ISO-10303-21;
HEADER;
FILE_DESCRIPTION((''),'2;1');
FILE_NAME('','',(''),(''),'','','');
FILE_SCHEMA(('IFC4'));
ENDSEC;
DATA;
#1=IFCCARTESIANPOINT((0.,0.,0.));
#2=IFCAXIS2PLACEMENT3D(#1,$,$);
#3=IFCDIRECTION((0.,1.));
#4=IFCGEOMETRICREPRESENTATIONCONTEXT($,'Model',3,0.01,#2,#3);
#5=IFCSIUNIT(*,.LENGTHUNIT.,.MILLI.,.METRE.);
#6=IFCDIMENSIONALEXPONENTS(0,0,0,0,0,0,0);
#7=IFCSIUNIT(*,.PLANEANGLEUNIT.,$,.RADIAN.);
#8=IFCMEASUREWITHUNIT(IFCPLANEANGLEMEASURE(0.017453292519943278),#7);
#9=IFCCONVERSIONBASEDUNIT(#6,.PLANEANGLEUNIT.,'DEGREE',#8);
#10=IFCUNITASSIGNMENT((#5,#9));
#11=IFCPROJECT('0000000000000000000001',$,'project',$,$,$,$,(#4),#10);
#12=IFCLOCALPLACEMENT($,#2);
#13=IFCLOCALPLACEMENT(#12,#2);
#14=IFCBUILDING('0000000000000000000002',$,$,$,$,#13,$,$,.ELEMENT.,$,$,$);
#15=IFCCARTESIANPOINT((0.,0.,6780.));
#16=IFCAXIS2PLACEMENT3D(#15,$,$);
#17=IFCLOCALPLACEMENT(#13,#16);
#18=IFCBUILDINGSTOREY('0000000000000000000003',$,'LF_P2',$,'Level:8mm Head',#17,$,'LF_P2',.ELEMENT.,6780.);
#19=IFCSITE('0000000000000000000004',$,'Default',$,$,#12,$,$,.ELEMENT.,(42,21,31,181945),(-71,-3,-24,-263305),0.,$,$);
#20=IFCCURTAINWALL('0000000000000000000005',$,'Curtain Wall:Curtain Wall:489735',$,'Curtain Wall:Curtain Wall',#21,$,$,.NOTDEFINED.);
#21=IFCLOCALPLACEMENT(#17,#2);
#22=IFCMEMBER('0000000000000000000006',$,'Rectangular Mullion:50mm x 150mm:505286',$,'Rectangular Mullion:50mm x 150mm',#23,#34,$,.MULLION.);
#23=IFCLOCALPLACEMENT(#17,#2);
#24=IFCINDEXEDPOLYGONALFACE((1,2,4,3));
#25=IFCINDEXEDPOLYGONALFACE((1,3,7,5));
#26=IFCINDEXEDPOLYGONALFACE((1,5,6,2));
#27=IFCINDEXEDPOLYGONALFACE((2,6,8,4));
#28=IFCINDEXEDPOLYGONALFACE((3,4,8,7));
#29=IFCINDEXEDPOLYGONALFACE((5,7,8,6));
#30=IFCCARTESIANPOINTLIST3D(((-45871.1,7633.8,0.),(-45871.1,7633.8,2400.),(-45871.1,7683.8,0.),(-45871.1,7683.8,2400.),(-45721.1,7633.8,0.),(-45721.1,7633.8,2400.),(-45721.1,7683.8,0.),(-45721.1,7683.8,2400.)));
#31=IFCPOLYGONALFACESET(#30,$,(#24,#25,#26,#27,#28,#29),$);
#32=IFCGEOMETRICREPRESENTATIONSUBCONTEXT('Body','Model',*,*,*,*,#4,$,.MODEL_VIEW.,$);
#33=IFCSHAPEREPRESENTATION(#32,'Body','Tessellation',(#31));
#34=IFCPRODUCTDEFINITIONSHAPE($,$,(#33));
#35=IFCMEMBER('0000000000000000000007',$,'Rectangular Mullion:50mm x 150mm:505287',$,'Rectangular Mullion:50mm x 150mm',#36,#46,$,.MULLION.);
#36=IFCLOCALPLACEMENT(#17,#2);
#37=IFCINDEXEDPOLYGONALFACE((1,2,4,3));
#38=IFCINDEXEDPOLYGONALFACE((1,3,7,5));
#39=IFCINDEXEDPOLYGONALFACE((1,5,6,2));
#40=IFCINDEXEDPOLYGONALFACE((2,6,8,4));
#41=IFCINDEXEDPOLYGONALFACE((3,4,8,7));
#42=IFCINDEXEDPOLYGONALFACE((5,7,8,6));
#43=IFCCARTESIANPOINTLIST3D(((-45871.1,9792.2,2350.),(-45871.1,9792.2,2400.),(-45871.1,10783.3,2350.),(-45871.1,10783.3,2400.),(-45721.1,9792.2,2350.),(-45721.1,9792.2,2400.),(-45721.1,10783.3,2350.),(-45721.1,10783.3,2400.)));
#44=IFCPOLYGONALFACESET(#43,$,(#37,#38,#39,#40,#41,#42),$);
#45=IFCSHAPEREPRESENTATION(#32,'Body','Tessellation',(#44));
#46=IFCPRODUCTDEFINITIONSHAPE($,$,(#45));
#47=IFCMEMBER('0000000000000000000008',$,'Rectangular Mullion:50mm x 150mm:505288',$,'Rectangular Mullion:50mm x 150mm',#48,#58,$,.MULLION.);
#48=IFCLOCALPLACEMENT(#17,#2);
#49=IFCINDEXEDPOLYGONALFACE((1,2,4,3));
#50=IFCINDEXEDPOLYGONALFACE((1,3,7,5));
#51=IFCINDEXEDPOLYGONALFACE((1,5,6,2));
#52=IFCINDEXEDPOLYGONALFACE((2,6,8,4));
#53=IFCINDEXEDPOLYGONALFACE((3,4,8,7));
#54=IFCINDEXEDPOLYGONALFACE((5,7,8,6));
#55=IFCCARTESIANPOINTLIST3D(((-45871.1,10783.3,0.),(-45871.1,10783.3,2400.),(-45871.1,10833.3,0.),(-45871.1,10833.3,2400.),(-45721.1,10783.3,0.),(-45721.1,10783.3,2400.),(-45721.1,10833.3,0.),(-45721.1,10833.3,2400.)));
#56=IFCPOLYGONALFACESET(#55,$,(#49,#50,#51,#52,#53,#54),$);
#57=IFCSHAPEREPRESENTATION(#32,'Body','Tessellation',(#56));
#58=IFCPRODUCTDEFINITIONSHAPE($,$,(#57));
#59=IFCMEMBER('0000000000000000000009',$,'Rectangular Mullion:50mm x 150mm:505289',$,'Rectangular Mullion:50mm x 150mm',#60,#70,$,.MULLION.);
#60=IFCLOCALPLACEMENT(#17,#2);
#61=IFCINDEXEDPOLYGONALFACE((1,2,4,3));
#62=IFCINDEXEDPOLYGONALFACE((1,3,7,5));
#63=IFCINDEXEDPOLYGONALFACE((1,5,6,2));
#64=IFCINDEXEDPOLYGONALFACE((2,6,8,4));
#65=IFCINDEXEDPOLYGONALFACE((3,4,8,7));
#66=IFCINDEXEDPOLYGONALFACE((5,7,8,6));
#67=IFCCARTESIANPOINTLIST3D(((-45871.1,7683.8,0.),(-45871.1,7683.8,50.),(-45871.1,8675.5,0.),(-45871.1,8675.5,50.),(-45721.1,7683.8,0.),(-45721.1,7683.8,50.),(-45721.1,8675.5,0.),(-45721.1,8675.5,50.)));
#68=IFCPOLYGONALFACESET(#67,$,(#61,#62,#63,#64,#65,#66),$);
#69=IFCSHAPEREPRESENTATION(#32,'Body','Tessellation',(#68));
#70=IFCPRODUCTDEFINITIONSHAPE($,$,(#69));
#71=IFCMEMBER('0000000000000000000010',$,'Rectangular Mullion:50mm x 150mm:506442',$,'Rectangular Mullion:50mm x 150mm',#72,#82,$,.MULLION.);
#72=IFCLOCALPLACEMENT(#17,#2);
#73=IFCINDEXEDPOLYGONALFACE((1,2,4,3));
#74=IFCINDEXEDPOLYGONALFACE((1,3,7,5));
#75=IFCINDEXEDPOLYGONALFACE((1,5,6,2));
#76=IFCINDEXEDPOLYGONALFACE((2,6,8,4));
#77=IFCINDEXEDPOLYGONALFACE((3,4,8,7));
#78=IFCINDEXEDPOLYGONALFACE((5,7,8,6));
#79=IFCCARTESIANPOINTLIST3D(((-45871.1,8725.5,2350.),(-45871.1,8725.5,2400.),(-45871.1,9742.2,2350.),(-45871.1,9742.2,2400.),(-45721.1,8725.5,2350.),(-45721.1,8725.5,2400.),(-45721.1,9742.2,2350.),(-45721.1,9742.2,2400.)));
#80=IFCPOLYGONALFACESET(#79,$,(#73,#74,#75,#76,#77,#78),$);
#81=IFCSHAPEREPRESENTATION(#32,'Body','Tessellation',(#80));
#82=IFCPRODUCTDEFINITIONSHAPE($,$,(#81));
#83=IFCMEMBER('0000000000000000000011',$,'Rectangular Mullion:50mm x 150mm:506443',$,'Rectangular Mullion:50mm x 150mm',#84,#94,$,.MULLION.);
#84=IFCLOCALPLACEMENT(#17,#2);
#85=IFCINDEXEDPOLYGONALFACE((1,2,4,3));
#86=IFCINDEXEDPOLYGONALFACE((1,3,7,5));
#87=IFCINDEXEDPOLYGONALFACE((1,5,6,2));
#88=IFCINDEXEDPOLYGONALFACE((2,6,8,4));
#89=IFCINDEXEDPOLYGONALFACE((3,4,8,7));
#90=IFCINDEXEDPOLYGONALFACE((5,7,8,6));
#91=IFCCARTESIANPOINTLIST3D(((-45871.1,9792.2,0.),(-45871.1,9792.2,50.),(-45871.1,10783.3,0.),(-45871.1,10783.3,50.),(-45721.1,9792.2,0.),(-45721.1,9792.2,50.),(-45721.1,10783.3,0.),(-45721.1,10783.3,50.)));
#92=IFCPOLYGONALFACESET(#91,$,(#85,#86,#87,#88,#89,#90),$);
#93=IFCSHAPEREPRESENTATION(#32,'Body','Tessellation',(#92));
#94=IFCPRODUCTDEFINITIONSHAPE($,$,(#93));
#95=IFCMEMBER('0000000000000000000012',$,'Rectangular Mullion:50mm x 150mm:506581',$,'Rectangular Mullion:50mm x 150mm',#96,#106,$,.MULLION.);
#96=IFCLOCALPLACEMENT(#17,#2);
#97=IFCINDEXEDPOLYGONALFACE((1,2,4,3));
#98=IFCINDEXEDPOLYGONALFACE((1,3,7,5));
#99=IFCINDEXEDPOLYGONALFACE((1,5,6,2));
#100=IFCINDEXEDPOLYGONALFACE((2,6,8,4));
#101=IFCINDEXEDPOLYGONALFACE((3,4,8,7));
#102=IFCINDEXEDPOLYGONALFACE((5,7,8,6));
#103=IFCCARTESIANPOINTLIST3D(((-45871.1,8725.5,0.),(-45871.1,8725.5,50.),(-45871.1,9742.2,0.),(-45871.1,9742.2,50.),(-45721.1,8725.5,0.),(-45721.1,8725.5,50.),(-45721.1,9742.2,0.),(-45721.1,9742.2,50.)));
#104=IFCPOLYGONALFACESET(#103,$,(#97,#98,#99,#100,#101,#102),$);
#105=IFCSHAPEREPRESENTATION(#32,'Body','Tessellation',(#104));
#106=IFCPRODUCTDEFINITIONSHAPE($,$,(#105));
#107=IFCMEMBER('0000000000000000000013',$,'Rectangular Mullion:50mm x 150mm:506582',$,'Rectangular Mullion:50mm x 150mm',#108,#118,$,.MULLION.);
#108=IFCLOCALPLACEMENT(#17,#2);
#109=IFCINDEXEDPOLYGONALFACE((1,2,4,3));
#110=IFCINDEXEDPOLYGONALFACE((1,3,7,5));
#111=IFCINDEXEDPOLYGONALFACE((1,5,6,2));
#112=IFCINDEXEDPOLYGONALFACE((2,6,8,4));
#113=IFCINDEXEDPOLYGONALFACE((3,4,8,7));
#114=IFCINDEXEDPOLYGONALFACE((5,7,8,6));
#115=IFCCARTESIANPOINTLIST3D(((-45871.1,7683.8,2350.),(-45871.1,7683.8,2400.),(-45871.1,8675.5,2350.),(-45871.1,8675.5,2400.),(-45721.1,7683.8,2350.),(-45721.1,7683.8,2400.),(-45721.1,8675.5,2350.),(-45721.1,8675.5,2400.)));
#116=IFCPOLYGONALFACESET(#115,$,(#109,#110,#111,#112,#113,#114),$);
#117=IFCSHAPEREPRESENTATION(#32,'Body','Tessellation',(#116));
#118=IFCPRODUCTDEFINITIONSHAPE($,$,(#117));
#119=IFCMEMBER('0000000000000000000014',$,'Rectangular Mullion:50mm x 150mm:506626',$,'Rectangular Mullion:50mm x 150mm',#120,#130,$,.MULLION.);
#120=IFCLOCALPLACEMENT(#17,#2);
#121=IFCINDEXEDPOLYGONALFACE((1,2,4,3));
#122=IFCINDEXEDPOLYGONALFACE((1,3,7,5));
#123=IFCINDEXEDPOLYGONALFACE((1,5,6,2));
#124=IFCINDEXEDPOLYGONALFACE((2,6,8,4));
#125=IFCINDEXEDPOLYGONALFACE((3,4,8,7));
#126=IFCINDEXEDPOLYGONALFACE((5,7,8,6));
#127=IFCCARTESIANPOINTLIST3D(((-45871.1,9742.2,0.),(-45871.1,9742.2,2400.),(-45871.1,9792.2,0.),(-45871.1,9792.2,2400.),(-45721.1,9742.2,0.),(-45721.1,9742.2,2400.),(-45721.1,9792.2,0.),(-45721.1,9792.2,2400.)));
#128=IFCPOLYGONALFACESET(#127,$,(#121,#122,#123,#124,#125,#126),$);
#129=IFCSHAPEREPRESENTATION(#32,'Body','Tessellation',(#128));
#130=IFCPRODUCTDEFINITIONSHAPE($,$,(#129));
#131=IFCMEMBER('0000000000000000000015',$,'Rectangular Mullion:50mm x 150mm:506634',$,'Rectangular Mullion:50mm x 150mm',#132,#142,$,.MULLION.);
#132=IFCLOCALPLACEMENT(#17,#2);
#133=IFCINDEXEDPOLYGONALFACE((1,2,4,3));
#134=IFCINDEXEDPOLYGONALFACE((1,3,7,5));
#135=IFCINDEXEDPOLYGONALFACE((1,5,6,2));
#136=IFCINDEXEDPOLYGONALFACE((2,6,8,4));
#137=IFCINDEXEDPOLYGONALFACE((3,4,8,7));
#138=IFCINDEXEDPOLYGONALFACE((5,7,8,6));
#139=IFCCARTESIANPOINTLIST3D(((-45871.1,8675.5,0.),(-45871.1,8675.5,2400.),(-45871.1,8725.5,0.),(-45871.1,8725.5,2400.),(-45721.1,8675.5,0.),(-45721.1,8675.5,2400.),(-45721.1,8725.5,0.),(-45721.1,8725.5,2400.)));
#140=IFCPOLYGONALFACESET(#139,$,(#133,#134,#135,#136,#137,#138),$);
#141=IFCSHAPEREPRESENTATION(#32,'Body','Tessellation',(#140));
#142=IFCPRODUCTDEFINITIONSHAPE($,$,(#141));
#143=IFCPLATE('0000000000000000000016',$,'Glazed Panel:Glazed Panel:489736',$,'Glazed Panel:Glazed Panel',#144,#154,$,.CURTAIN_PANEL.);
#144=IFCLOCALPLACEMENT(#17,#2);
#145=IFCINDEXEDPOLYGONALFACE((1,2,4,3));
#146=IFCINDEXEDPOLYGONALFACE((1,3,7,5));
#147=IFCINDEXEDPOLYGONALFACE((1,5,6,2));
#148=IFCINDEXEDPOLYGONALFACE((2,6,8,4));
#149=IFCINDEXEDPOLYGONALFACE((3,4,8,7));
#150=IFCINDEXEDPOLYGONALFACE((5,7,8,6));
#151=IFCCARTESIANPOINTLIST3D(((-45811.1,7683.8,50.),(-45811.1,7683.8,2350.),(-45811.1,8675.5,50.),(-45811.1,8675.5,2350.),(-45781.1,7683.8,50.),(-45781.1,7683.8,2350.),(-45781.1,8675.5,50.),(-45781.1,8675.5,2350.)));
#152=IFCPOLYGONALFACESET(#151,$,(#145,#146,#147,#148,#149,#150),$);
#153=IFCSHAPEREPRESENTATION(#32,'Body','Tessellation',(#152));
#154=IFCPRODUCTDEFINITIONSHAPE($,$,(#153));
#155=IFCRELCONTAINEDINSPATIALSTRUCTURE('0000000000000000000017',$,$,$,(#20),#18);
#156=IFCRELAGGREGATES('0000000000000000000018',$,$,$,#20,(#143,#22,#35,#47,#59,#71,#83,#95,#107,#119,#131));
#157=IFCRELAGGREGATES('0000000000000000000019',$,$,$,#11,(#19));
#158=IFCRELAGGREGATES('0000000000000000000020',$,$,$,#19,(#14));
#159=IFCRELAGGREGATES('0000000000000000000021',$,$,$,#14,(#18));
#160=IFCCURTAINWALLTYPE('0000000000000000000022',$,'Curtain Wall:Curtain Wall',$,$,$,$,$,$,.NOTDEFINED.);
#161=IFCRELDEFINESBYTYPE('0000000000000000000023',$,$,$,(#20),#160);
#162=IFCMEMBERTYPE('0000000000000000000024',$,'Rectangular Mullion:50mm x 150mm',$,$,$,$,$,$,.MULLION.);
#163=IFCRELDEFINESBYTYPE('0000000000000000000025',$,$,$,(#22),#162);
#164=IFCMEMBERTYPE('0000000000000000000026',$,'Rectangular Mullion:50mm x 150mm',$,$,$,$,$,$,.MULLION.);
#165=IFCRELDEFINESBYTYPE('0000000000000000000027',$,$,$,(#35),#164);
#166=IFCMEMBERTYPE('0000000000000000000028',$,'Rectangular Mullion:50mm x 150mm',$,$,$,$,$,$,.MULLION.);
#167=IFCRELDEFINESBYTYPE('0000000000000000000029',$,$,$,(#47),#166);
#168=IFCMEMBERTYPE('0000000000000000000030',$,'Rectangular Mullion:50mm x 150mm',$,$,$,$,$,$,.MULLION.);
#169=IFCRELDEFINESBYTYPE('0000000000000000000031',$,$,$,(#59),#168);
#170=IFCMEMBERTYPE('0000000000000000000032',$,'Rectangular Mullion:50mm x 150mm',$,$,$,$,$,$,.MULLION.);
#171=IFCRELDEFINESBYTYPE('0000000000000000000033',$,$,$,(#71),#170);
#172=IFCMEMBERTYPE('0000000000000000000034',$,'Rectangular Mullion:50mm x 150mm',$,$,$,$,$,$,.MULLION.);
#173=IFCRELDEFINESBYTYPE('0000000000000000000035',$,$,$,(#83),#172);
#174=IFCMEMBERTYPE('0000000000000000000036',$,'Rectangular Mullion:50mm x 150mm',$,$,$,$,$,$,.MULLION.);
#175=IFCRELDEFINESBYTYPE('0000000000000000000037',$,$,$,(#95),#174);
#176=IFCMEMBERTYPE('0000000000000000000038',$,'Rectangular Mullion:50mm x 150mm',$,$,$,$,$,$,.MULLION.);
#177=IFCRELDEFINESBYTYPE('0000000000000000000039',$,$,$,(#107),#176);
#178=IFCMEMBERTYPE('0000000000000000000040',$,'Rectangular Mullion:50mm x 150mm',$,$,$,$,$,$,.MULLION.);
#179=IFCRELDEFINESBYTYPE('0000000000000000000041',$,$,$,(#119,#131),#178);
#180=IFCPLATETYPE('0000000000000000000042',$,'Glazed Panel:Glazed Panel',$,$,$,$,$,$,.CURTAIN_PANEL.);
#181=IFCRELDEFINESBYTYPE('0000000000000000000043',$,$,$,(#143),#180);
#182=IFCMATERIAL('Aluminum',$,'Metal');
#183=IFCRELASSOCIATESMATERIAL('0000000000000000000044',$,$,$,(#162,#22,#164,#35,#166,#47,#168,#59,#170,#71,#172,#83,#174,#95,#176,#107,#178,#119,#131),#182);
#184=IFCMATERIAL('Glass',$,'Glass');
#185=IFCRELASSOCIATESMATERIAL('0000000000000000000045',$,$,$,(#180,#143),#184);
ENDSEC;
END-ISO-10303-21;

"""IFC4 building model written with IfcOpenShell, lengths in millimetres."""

from ifc_helpers import new_model, entity, si_unit, converted_unit, direction, frame, origin, place, context, subcontext, project, spatial, indexed_curve, outline, extrude, source, transform, mapped, material, type_object, type_shapes, element, aggregate, save


model = new_model("IFC4")

# Units and contexts
model_context = context("Model", 3, precision=0.01, world=origin(), true_north=direction((0.0, 1.0)))
body_context = subcontext(model_context, "Body", "Model", "MODEL_VIEW")
ifc_project = project(units=[si_unit("LENGTHUNIT", "METRE", prefix="MILLI"), converted_unit("PLANEANGLEUNIT", "DEGREE", entity("IfcPlaneAngleMeasure", 0.017453292519943278), si_unit("PLANEANGLEUNIT", "RADIAN"), dimensions=[0, 0, 0, 0, 0, 0, 0])], contexts=[model_context])

# Site, building, storey
site_placement = place(None, origin())
site = spatial("IfcSite", under=ifc_project, at=site_placement, Name="Default", CompositionType="ELEMENT", RefLatitude=(42, 21, 31, 181945), RefLongitude=(-71, -3, -24, -263305), RefElevation=0.0)
building_placement = place(site_placement, origin())
building = spatial("IfcBuilding", under=site, at=building_placement, CompositionType="ELEMENT")
storey_placement = place(building_placement, frame((0.0, 0.0, 6780.0)))
storey = spatial("IfcBuildingStorey", under=building, at=storey_placement, Name="LF_P2", ObjectType="Level:8mm Head", LongName="LF_P2", CompositionType="ELEMENT", Elevation=6780.0)

# Curtain wall, members, plate
curtain_wall_type = type_object("IfcCurtainWallType", Name="Curtain Wall:Curtain Wall", PredefinedType="NOTDEFINED")
curtain_wall_placement = place(storey_placement, frame((0.0, 0.0, -6780.0)))
curtain_wall = element("IfcCurtainWall", 1, at=curtain_wall_placement, inside=storey, type_object=curtain_wall_type, Name="Curtain Wall:Curtain Wall:489735", ObjectType="Curtain Wall:Curtain Wall", PredefinedType="NOTDEFINED")
ifc_material_1 = material(Name="Aluminum", Category="Metal")
member_type_1 = type_object("IfcMemberType", Name="Rectangular Mullion:50mm x 150mm", PredefinedType="MULLION", material=ifc_material_1)
shared_shape_1 = source(origin(), body_context, "Body", "SweptSolid", [
    extrude(outline(indexed_curve([(-25.0, -75.0), (25.0, -75.0), (25.0, 75.0), (-25.0, 75.0), (-25.0, -75.0)], self_intersect=False)), frame((-25.0, 0.0, -2400.0), z_axis=(0.0, 0.0, 1.0), x_axis=(-1.0, 0.0, 0.0)), (0.0, 0.0, 1.0), 2400.0),
])
type_shapes(member_type_1, [shared_shape_1])
member_1_placement = place(curtain_wall_placement, frame((-45796.1, 7633.8, 9180.0), z_axis=(0.0, 0.0, 1.0), x_axis=(0.0, -1.0, 0.0)))
member_1 = element("IfcMember", 2, at=member_1_placement, type_object=member_type_1, material=ifc_material_1, Name="Rectangular Mullion:50mm x 150mm:505286", ObjectType="Rectangular Mullion:50mm x 150mm", PredefinedType="MULLION", context=body_context, shape_type="MappedRepresentation", body=[
    mapped(shared_shape_1, transform((0.0, 0.0, 0.0), scale=1.0)),
])
member_type_2 = type_object("IfcMemberType", Name="Rectangular Mullion:50mm x 150mm", PredefinedType="MULLION", material=ifc_material_1)
shared_shape_2 = source(origin(), body_context, "Body", "SweptSolid", [
    extrude(outline(indexed_curve([(-25.0, -75.0), (25.0, -75.0), (25.0, 75.0), (-25.0, 75.0), (-25.0, -75.0)], self_intersect=False)), frame((-25.0, 0.0, -991.2), z_axis=(0.0, 0.0, 1.0), x_axis=(-1.0, 0.0, 0.0)), (0.0, 0.0, 1.0), 991.2),
])
type_shapes(member_type_2, [shared_shape_2])
member_2_placement = place(curtain_wall_placement, frame((-45796.1, 10783.3, 9180.0), z_axis=(0.0, 1.0, 0.0), x_axis=(0.0, 0.0, 1.0)))
member_2 = element("IfcMember", 3, at=member_2_placement, type_object=member_type_2, material=ifc_material_1, Name="Rectangular Mullion:50mm x 150mm:505287", ObjectType="Rectangular Mullion:50mm x 150mm", PredefinedType="MULLION", context=body_context, shape_type="MappedRepresentation", body=[
    mapped(shared_shape_2, transform((0.0, 0.0, 0.0), scale=1.0)),
])
member_type_3 = type_object("IfcMemberType", Name="Rectangular Mullion:50mm x 150mm", PredefinedType="MULLION", material=ifc_material_1)
shared_shape_3 = source(origin(), body_context, "Body", "SweptSolid", [
    extrude(outline(indexed_curve([(-25.0, -75.0), (25.0, -75.0), (25.0, 75.0), (-25.0, 75.0), (-25.0, -75.0)], self_intersect=False)), frame((-25.0, 0.0, -2400.0), z_axis=(0.0, 0.0, 1.0), x_axis=(-1.0, 0.0, 0.0)), (0.0, 0.0, 1.0), 2400.0),
])
type_shapes(member_type_3, [shared_shape_3])
member_3_placement = place(curtain_wall_placement, frame((-45796.1, 10833.3, 6780.0), z_axis=(0.0, 0.0, -1.0), x_axis=(0.0, 1.0, 0.0)))
member_3 = element("IfcMember", 4, at=member_3_placement, type_object=member_type_3, material=ifc_material_1, Name="Rectangular Mullion:50mm x 150mm:505288", ObjectType="Rectangular Mullion:50mm x 150mm", PredefinedType="MULLION", context=body_context, shape_type="MappedRepresentation", body=[
    mapped(shared_shape_3, transform((0.0, 0.0, 0.0), scale=1.0)),
])
member_type_4 = type_object("IfcMemberType", Name="Rectangular Mullion:50mm x 150mm", PredefinedType="MULLION", material=ifc_material_1)
shared_shape_4 = source(origin(), body_context, "Body", "SweptSolid", [
    extrude(outline(indexed_curve([(-25.0, -75.0), (25.0, -75.0), (25.0, 75.0), (-25.0, 75.0), (-25.0, -75.0)], self_intersect=False)), frame((-25.0, 0.0, -991.7), z_axis=(0.0, 0.0, 1.0), x_axis=(-1.0, 0.0, 0.0)), (0.0, 0.0, 1.0), 991.7),
])
type_shapes(member_type_4, [shared_shape_4])
member_4_placement = place(curtain_wall_placement, frame((-45796.1, 7683.8, 6780.0), z_axis=(0.0, -1.0, 0.0), x_axis=(0.0, 0.0, -1.0)))
member_4 = element("IfcMember", 5, at=member_4_placement, type_object=member_type_4, material=ifc_material_1, Name="Rectangular Mullion:50mm x 150mm:505289", ObjectType="Rectangular Mullion:50mm x 150mm", PredefinedType="MULLION", context=body_context, shape_type="MappedRepresentation", body=[
    mapped(shared_shape_4, transform((0.0, 0.0, 0.0), scale=1.0)),
])
member_type_5 = type_object("IfcMemberType", Name="Rectangular Mullion:50mm x 150mm", PredefinedType="MULLION", material=ifc_material_1)
shared_shape_5 = source(origin(), body_context, "Body", "SweptSolid", [
    extrude(outline(indexed_curve([(-25.0, -75.0), (25.0, -75.0), (25.0, 75.0), (-25.0, 75.0), (-25.0, -75.0)], self_intersect=False)), frame((-25.0, 0.0, -1016.7), z_axis=(0.0, 0.0, 1.0), x_axis=(-1.0, 0.0, 0.0)), (0.0, 0.0, 1.0), 1016.7),
])
type_shapes(member_type_5, [shared_shape_5])
member_5_placement = place(curtain_wall_placement, frame((-45796.1, 9742.2, 9180.0), z_axis=(0.0, 1.0, 0.0), x_axis=(0.0, 0.0, 1.0)))
member_5 = element("IfcMember", 6, at=member_5_placement, type_object=member_type_5, material=ifc_material_1, Name="Rectangular Mullion:50mm x 150mm:506442", ObjectType="Rectangular Mullion:50mm x 150mm", PredefinedType="MULLION", context=body_context, shape_type="MappedRepresentation", body=[
    mapped(shared_shape_5, transform((0.0, 0.0, 0.0), scale=1.0)),
])
member_type_6 = type_object("IfcMemberType", Name="Rectangular Mullion:50mm x 150mm", PredefinedType="MULLION", material=ifc_material_1)
shared_shape_6 = source(origin(), body_context, "Body", "SweptSolid", [
    extrude(outline(indexed_curve([(-25.0, -75.0), (25.0, -75.0), (25.0, 75.0), (-25.0, 75.0), (-25.0, -75.0)], self_intersect=False)), frame((-25.0, 0.0, -991.2), z_axis=(0.0, 0.0, 1.0), x_axis=(-1.0, 0.0, 0.0)), (0.0, 0.0, 1.0), 991.2),
])
type_shapes(member_type_6, [shared_shape_6])
member_6_placement = place(curtain_wall_placement, frame((-45796.1, 9792.2, 6780.0), z_axis=(0.0, -1.0, 0.0), x_axis=(0.0, 0.0, -1.0)))
member_6 = element("IfcMember", 7, at=member_6_placement, type_object=member_type_6, material=ifc_material_1, Name="Rectangular Mullion:50mm x 150mm:506443", ObjectType="Rectangular Mullion:50mm x 150mm", PredefinedType="MULLION", context=body_context, shape_type="MappedRepresentation", body=[
    mapped(shared_shape_6, transform((0.0, 0.0, 0.0), scale=1.0)),
])
member_type_7 = type_object("IfcMemberType", Name="Rectangular Mullion:50mm x 150mm", PredefinedType="MULLION", material=ifc_material_1)
shared_shape_7 = source(origin(), body_context, "Body", "SweptSolid", [
    extrude(outline(indexed_curve([(-25.0, -75.0), (25.0, -75.0), (25.0, 75.0), (-25.0, 75.0), (-25.0, -75.0)], self_intersect=False)), frame((-25.0, 0.0, -1016.7), z_axis=(0.0, 0.0, 1.0), x_axis=(-1.0, 0.0, 0.0)), (0.0, 0.0, 1.0), 1016.7),
])
type_shapes(member_type_7, [shared_shape_7])
member_7_placement = place(curtain_wall_placement, frame((-45796.1, 8725.5, 6780.0), z_axis=(0.0, -1.0, 0.0), x_axis=(0.0, 0.0, -1.0)))
member_7 = element("IfcMember", 8, at=member_7_placement, type_object=member_type_7, material=ifc_material_1, Name="Rectangular Mullion:50mm x 150mm:506581", ObjectType="Rectangular Mullion:50mm x 150mm", PredefinedType="MULLION", context=body_context, shape_type="MappedRepresentation", body=[
    mapped(shared_shape_7, transform((0.0, 0.0, 0.0), scale=1.0)),
])
member_type_8 = type_object("IfcMemberType", Name="Rectangular Mullion:50mm x 150mm", PredefinedType="MULLION", material=ifc_material_1)
shared_shape_8 = source(origin(), body_context, "Body", "SweptSolid", [
    extrude(outline(indexed_curve([(-25.0, -75.0), (25.0, -75.0), (25.0, 75.0), (-25.0, 75.0), (-25.0, -75.0)], self_intersect=False)), frame((-25.0, 0.0, -991.7), z_axis=(0.0, 0.0, 1.0), x_axis=(-1.0, 0.0, 0.0)), (0.0, 0.0, 1.0), 991.7),
])
type_shapes(member_type_8, [shared_shape_8])
member_8_placement = place(curtain_wall_placement, frame((-45796.1, 8675.5, 9180.0), z_axis=(0.0, 1.0, 0.0), x_axis=(0.0, 0.0, 1.0)))
member_8 = element("IfcMember", 9, at=member_8_placement, type_object=member_type_8, material=ifc_material_1, Name="Rectangular Mullion:50mm x 150mm:506582", ObjectType="Rectangular Mullion:50mm x 150mm", PredefinedType="MULLION", context=body_context, shape_type="MappedRepresentation", body=[
    mapped(shared_shape_8, transform((0.0, 0.0, 0.0), scale=1.0)),
])
member_type_9 = type_object("IfcMemberType", Name="Rectangular Mullion:50mm x 150mm", PredefinedType="MULLION", material=ifc_material_1)
shared_shape_9 = source(origin(), body_context, "Body", "SweptSolid", [
    extrude(outline(indexed_curve([(-25.0, -75.0), (25.0, -75.0), (25.0, 75.0), (-25.0, 75.0), (-25.0, -75.0)], self_intersect=False)), frame((0.0, 0.0, -2400.0), z_axis=(0.0, 0.0, 1.0), x_axis=(-1.0, 0.0, 0.0)), (0.0, 0.0, 1.0), 2400.0),
])
type_shapes(member_type_9, [shared_shape_9])
member_9_placement = place(curtain_wall_placement, frame((-45796.1, 9767.2, 6780.0), z_axis=(0.0, 0.0, -1.0), x_axis=(0.0, 1.0, 0.0)))
member_9 = element("IfcMember", 10, at=member_9_placement, type_object=member_type_9, material=ifc_material_1, Name="Rectangular Mullion:50mm x 150mm:506626", ObjectType="Rectangular Mullion:50mm x 150mm", PredefinedType="MULLION", context=body_context, shape_type="MappedRepresentation", body=[
    mapped(shared_shape_9, transform((0.0, 0.0, 0.0), scale=1.0)),
])
member_10_placement = place(curtain_wall_placement, frame((-45796.1, 8700.5, 6780.0), z_axis=(0.0, 0.0, -1.0), x_axis=(0.0, 1.0, 0.0)))
member_10 = element("IfcMember", 11, at=member_10_placement, type_object=member_type_9, material=ifc_material_1, Name="Rectangular Mullion:50mm x 150mm:506634", ObjectType="Rectangular Mullion:50mm x 150mm", PredefinedType="MULLION", context=body_context, shape_type="MappedRepresentation", body=[
    mapped(shared_shape_9, transform((0.0, 0.0, 0.0), scale=1.0)),
])
ifc_material_2 = material(Name="Glass", Category="Glass")
plate_type_1 = type_object("IfcPlateType", Name="Glazed Panel:Glazed Panel", PredefinedType="CURTAIN_PANEL", material=ifc_material_2)
shared_shape_10 = source(origin(), body_context, "Body", "SweptSolid", [
    extrude(outline(indexed_curve([(-15.0, -495.8), (15.0, -495.8), (15.0, 495.8), (-15.0, 495.8), (-15.0, -495.8)], self_intersect=False)), frame((0.0, 0.0, 0.0), z_axis=(0.0, 0.0, 1.0), x_axis=(0.0, 1.0, 0.0)), (0.0, 0.0, 1.0), 2300.0),
])
type_shapes(plate_type_1, [shared_shape_10])
plate_1_placement = place(curtain_wall_placement, frame((-45796.1, 8179.7, 6830.0), z_axis=(0.0, 0.0, 1.0), x_axis=(0.0, 1.0, 0.0)))
plate_1 = element("IfcPlate", 12, at=plate_1_placement, type_object=plate_type_1, material=ifc_material_2, Name="Glazed Panel:Glazed Panel:489736", ObjectType="Glazed Panel:Glazed Panel", PredefinedType="CURTAIN_PANEL", context=body_context, shape_type="MappedRepresentation", body=[
    mapped(shared_shape_10, transform((0.0, 0.0, 0.0), scale=1.0)),
])
aggregate(curtain_wall, [plate_1, member_1, member_2, member_3, member_4, member_5, member_6, member_7, member_8, member_9, member_10])

save(model, "model.ifc")
